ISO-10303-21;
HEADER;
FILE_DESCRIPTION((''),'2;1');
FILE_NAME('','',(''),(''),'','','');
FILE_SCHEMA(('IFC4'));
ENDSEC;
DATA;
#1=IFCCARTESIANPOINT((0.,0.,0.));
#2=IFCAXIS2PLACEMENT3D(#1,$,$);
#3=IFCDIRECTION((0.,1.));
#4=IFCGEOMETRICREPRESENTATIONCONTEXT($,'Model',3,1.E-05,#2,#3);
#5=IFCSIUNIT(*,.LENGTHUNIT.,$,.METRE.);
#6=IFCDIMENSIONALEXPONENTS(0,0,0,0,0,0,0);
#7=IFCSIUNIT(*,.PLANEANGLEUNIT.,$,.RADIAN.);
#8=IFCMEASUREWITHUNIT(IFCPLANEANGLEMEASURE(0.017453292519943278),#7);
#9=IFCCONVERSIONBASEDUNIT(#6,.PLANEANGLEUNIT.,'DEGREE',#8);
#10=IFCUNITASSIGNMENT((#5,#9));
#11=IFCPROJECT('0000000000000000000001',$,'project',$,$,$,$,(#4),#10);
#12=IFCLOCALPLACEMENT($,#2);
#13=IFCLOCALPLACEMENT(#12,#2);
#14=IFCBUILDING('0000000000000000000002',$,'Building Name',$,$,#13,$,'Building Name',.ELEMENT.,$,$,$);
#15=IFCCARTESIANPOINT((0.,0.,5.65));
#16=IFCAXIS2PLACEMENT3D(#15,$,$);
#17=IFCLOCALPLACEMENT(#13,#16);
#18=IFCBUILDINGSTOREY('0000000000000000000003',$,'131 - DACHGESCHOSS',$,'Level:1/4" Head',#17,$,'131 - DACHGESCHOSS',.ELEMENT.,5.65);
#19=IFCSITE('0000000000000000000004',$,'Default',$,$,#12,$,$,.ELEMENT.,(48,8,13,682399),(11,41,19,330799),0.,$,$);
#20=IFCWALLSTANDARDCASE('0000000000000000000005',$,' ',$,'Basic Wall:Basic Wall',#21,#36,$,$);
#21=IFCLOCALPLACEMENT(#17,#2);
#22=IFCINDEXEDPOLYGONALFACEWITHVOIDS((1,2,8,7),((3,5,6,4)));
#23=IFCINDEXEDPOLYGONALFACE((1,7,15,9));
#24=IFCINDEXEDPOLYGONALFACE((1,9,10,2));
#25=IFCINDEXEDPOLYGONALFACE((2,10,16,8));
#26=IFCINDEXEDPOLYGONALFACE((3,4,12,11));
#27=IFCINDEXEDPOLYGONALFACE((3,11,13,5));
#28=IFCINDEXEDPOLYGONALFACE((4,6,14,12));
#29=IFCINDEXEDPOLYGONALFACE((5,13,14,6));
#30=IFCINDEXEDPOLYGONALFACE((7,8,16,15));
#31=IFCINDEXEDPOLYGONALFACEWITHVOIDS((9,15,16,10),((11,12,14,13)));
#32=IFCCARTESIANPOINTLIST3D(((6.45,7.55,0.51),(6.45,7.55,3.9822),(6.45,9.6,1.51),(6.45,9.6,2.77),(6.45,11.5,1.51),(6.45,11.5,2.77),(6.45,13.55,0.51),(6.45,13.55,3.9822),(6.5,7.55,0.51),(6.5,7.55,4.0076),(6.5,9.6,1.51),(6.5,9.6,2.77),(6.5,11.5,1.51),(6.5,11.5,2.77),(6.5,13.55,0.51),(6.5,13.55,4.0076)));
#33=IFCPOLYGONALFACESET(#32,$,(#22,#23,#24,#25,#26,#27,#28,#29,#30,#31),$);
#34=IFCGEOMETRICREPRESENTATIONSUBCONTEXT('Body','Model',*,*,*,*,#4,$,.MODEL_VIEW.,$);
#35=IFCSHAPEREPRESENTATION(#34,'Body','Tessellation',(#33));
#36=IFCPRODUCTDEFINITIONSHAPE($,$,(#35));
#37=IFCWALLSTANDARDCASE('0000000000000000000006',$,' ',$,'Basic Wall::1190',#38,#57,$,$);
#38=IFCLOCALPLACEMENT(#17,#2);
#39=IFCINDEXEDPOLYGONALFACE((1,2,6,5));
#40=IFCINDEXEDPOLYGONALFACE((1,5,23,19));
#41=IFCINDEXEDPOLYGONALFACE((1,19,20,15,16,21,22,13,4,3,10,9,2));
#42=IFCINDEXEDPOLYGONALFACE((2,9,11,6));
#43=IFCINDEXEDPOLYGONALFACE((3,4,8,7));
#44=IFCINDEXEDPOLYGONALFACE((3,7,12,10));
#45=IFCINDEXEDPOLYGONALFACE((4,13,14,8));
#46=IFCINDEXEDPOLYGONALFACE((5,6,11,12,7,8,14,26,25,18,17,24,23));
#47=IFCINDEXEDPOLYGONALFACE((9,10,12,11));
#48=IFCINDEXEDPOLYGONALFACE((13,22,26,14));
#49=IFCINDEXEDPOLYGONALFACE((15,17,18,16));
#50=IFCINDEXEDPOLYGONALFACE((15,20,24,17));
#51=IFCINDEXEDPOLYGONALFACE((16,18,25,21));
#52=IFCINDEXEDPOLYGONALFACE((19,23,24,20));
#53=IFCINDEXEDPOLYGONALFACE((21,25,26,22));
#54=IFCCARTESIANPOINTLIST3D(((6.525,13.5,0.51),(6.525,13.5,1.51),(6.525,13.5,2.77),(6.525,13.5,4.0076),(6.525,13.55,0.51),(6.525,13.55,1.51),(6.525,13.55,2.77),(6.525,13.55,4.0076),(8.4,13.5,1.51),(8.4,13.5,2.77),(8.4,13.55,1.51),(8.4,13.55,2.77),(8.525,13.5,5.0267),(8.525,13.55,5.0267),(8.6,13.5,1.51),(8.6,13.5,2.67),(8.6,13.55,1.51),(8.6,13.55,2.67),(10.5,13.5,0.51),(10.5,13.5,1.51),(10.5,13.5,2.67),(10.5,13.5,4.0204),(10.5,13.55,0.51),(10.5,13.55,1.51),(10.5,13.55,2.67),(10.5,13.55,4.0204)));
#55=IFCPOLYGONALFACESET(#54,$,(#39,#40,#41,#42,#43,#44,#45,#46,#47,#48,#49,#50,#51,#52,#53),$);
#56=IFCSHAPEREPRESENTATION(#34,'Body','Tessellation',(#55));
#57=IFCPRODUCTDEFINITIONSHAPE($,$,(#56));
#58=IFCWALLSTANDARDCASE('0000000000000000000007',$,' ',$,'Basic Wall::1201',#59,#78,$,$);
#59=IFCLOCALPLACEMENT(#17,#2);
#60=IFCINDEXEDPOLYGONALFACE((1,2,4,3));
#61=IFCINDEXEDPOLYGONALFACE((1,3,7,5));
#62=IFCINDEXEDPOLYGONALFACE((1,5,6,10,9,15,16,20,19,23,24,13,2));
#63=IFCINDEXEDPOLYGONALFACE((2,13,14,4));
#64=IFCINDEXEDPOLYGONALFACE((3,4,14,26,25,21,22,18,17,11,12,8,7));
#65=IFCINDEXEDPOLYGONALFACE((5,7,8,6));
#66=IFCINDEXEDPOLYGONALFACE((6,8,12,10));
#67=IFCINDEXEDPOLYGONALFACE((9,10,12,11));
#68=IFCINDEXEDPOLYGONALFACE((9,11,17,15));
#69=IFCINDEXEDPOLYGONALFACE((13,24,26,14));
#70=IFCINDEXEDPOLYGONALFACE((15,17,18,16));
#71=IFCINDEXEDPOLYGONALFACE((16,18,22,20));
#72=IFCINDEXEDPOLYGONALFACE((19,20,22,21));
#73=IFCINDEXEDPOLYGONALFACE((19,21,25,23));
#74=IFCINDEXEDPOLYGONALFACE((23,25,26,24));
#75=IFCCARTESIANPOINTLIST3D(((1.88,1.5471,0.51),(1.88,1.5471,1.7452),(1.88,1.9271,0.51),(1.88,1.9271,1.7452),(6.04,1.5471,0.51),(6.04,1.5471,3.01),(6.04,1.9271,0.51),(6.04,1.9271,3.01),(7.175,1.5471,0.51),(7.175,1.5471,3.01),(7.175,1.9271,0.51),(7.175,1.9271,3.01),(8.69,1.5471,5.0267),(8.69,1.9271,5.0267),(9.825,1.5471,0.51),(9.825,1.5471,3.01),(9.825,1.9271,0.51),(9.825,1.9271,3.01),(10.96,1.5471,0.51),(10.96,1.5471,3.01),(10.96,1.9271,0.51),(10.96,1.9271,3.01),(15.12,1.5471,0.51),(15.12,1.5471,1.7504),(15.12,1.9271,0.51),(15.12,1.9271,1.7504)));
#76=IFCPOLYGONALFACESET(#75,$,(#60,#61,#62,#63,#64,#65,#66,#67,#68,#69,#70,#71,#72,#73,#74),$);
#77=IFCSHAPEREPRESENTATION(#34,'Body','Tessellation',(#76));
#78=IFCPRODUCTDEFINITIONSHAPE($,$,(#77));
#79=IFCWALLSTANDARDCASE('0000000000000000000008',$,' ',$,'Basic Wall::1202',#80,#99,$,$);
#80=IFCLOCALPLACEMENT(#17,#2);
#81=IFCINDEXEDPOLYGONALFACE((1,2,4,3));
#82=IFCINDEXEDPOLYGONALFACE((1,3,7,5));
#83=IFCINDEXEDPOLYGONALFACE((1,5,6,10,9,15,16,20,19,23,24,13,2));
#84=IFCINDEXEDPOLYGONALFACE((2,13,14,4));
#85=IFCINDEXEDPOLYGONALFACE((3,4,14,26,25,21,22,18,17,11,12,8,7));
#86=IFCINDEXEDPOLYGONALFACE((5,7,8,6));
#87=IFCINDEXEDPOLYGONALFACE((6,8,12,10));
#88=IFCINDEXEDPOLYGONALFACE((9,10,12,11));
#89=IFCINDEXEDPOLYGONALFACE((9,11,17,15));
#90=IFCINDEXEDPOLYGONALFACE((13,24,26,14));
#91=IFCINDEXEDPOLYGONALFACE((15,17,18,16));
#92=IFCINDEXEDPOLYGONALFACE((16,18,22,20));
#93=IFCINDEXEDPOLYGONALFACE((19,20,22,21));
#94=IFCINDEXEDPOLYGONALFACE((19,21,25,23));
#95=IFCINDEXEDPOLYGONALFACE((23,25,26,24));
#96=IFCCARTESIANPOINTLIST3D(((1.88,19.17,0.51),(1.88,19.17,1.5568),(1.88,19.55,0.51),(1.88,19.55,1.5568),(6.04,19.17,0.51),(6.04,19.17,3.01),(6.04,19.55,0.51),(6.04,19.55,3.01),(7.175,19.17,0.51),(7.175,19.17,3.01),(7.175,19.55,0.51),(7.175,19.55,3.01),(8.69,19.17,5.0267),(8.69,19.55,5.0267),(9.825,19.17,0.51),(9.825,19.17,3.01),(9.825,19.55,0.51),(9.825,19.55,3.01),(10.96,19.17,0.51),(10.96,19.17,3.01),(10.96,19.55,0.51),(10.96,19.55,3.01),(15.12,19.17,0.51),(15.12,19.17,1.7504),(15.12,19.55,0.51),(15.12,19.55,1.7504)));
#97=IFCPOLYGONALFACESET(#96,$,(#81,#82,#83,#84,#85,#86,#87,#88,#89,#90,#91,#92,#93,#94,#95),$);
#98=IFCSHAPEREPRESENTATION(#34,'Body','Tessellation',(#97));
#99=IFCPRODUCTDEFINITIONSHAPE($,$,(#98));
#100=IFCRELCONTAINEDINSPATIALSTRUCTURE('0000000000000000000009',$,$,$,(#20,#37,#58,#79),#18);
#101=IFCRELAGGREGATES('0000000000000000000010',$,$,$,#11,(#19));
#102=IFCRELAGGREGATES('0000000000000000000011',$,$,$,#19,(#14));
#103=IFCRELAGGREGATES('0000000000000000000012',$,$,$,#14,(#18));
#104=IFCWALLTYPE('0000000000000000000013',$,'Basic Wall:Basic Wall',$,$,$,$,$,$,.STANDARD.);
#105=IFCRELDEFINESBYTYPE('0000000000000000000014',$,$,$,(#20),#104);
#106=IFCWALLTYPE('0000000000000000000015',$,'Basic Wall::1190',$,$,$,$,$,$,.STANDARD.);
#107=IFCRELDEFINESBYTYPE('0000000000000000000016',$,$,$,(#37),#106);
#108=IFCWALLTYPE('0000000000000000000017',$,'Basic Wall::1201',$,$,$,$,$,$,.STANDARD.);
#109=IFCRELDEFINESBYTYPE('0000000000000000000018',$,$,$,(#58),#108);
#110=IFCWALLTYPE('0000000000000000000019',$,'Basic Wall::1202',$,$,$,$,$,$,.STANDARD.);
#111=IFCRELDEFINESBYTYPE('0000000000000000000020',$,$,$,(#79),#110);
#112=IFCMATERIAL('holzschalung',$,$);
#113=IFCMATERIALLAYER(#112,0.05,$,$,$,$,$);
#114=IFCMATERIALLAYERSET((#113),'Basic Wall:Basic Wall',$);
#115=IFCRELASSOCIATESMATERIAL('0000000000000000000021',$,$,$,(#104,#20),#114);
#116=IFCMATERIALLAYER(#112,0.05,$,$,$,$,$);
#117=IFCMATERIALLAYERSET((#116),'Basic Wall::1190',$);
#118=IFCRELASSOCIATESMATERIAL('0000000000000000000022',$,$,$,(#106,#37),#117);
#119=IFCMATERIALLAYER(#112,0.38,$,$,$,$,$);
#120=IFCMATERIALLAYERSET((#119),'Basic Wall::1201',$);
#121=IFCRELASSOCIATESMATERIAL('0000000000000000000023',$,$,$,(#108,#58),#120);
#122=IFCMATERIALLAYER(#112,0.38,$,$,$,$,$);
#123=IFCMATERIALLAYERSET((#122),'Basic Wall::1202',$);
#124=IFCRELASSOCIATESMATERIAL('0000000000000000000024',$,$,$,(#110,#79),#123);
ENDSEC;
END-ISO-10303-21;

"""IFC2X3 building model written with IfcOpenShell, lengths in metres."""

from ifc_helpers import new_model, entity, si_unit, converted_unit, direction, frame, frame_2d, origin, place, context, subcontext, project, spatial, rectangle, extrude, clip, halfspace, material, layer, layer_set, layer_usage, type_object, element, save


model = new_model("IFC2X3")

# Units and contexts
model_context = context("Model", 3, precision=1e-05, world=origin(), true_north=direction((0.0, 1.0)))
body_context = subcontext(model_context, "Body", "Model", "MODEL_VIEW")
ifc_project = project(units=[si_unit("LENGTHUNIT", "METRE"), converted_unit("PLANEANGLEUNIT", "DEGREE", entity("IfcPlaneAngleMeasure", 0.017453292519943278), si_unit("PLANEANGLEUNIT", "RADIAN"), dimensions=[0, 0, 0, 0, 0, 0, 0])], contexts=[model_context])

# Site, building, storey
site_placement = place(None, origin())
site = spatial("IfcSite", under=ifc_project, at=site_placement, Name="Default", CompositionType="ELEMENT", RefLatitude=(48, 8, 13, 682399), RefLongitude=(11, 41, 19, 330799), RefElevation=0.0)
building_placement = place(site_placement, origin())
building = spatial("IfcBuilding", under=site, at=building_placement, Name="Building Name", LongName="Building Name", CompositionType="ELEMENT")
storey_placement = place(building_placement, frame((0.0, 0.0, 5.65)))
storey = spatial("IfcBuildingStorey", under=building, at=storey_placement, Name="131 - DACHGESCHOSS", ObjectType="Level:1/4\" Head", LongName="131 - DACHGESCHOSS", CompositionType="ELEMENT", Elevation=5.65)

# Shared definitions
ifc_material = material(Name="holzschalung")

# Wall, openings
ifc_layer_1 = layer(ifc_material, 0.05)
ifc_layer_set_1 = layer_set([ifc_layer_1], Name="Basic Wall:Basic Wall")
ifc_layer_usage_1 = layer_usage(ifc_layer_set_1, "AXIS2", "NEGATIVE", 0.025)
wall_type_1 = type_object("IfcWallType", Name="Basic Wall:Basic Wall", PredefinedType="STANDARD", material=ifc_layer_set_1)
wall_1_placement = place(storey_placement, frame((6.475, 7.55, 0.51), z_axis=(0.0, 0.0, 1.0), x_axis=(0.0, 1.0, 0.0)))
wall_1 = element("IfcWallStandardCase", 1, at=wall_1_placement, inside=storey, type_object=wall_type_1, material=ifc_layer_usage_1, Name=" ", ObjectType="Basic Wall:Basic Wall", context=body_context, shape_type="SweptSolid", body=[
    extrude(rectangle(XDim=6.0, YDim=0.05, at=frame_2d((3.0, 0.0), x_axis=(-1.0, 0.0))), origin(), (0.0, 0.0, 1.0), 3.4976),
])
opening_1_placement = place(wall_1_placement, origin())
element("IfcOpeningElement", 2, at=opening_1_placement, cuts=wall_1, ObjectType="Opening", context=body_context, shape_type="SweptSolid", body=[
    extrude(rectangle(XDim=6.9075, YDim=13.815, at=frame_2d((0.0, 0.0), x_axis=(1.0, 0.0))), frame((3.0, -3.177, 8.9799), z_axis=(0.0, 0.891007, -0.45399), x_axis=(0.0, -0.45399, -0.891007)), (0.0, 0.0, 1.0), 13.815),
])
opening_2_placement = place(wall_1_placement, origin())
element("IfcOpeningElement", 3, at=opening_2_placement, cuts=wall_1, ObjectType="Opening", context=body_context, shape_type="SweptSolid", body=[
    extrude(rectangle(XDim=1.26, YDim=1.9, at=frame_2d((0.0, 0.0), x_axis=(0.0, 1.0))), frame((3.0, -0.025, 1.63), z_axis=(0.0, 1.0, 0.0), x_axis=(-1.0, 0.0, 0.0)), (0.0, 0.0, 1.0), 0.05),
])

# Walls, openings
ifc_layer_2 = layer(ifc_material, 0.05)
ifc_layer_set_2 = layer_set([ifc_layer_2], Name="Basic Wall::1190")
ifc_layer_usage_2 = layer_usage(ifc_layer_set_2, "AXIS2", "NEGATIVE", 0.025)
wall_type_2 = type_object("IfcWallType", Name="Basic Wall::1190", PredefinedType="STANDARD", material=ifc_layer_set_2)
wall_2_placement = place(storey_placement, frame((6.525, 13.525, 0.51)))
wall_2 = element("IfcWallStandardCase", 4, at=wall_2_placement, inside=storey, type_object=wall_type_2, material=ifc_layer_usage_2, Name=" ", ObjectType="Basic Wall::1190", context=body_context, shape_type="Clipping", body=[
    clip(clip(extrude(rectangle(XDim=3.975, YDim=0.05, at=frame_2d((1.9875, 0.0), x_axis=(-1.0, 0.0))), origin(), (0.0, 0.0, 1.0), 4.5167), halfspace(frame((0.0, -0.025, 3.4976), z_axis=(-0.45399, 0.0, 0.891007), x_axis=(0.0, 1.0, 0.0)), False)), halfspace(frame((2.0, -0.025, 4.5167), z_axis=(0.45399, 0.0, 0.891007), x_axis=(0.0, 1.0, 0.0)), False)),
])
opening_3_placement = place(wall_2_placement, origin())
element("IfcOpeningElement", 5, at=opening_3_placement, cuts=wall_2, ObjectType="Opening", context=body_context, shape_type="SweptSolid", body=[
    extrude(rectangle(XDim=1.26, YDim=1.9, at=frame_2d((0.0, 0.0), x_axis=(0.0, 1.0))), frame((0.925, -0.025, 1.63), z_axis=(0.0, 1.0, 0.0), x_axis=(-1.0, 0.0, 0.0)), (0.0, 0.0, 1.0), 0.05),
])
opening_4_placement = place(wall_2_placement, origin())
element("IfcOpeningElement", 6, at=opening_4_placement, cuts=wall_2, ObjectType="Opening", context=body_context, shape_type="SweptSolid", body=[
    extrude(rectangle(XDim=1.16, YDim=1.9, at=frame_2d((0.0, 0.0), x_axis=(0.0, 1.0))), frame((3.025, -0.025, 1.58), z_axis=(0.0, 1.0, 0.0), x_axis=(-1.0, 0.0, 0.0)), (0.0, 0.0, 1.0), 0.05),
])
ifc_layer_3 = layer(ifc_material, 0.38)
ifc_layer_set_3 = layer_set([ifc_layer_3], Name="Basic Wall::1201")
ifc_layer_usage_3 = layer_usage(ifc_layer_set_3, "AXIS2", "NEGATIVE", 0.19)
wall_type_3 = type_object("IfcWallType", Name="Basic Wall::1201", PredefinedType="STANDARD", material=ifc_layer_set_3)
wall_3_placement = place(storey_placement, frame((15.12, 1.7371, 0.51), z_axis=(0.0, 0.0, 1.0), x_axis=(-1.0, 0.0, 0.0)))
wall_3 = element("IfcWallStandardCase", 7, at=wall_3_placement, inside=storey, type_object=wall_type_3, material=ifc_layer_usage_3, Name=" ", ObjectType="Basic Wall::1201", context=body_context, shape_type="Clipping", body=[
    clip(clip(extrude(rectangle(XDim=13.24, YDim=0.38, at=frame_2d((6.62, 0.0), x_axis=(-1.0, 0.0))), origin(), (0.0, 0.0, 1.0), 4.5167), halfspace(frame((0.0, -0.19, 1.2404), z_axis=(-0.45399, 0.0, 0.891007), x_axis=(0.0, 1.0, 0.0)), False)), halfspace(frame((6.43, -0.19, 4.5167), z_axis=(0.434096, 0.0, 0.900866), x_axis=(0.0, 1.0, 0.0)), False)),
])
opening_5_placement = place(wall_3_placement, origin())
element("IfcOpeningElement", 8, at=opening_5_placement, cuts=wall_3, ObjectType="Opening", context=body_context, shape_type="SweptSolid", body=[
    extrude(rectangle(XDim=2.5, YDim=1.135, at=frame_2d((0.0, 0.0), x_axis=(1.0, 0.0))), frame((4.7275, -0.19, 1.25), z_axis=(0.0, 1.0, 0.0), x_axis=(0.0, 0.0, 1.0)), (0.0, 0.0, 1.0), 0.38),
])
opening_6_placement = place(wall_3_placement, origin())
element("IfcOpeningElement", 9, at=opening_6_placement, cuts=wall_3, ObjectType="Opening", context=body_context, shape_type="SweptSolid", body=[
    extrude(rectangle(XDim=2.5, YDim=1.135, at=frame_2d((0.0, 0.0), x_axis=(1.0, 0.0))), frame((8.5125, -0.19, 1.25), z_axis=(0.0, 1.0, 0.0), x_axis=(0.0, 0.0, 1.0)), (0.0, 0.0, 1.0), 0.38),
])
ifc_layer_4 = layer(ifc_material, 0.38)
ifc_layer_set_4 = layer_set([ifc_layer_4], Name="Basic Wall::1202")
ifc_layer_usage_4 = layer_usage(ifc_layer_set_4, "AXIS2", "NEGATIVE", 0.19)
wall_type_4 = type_object("IfcWallType", Name="Basic Wall::1202", PredefinedType="STANDARD", material=ifc_layer_set_4)
wall_4_placement = place(storey_placement, frame((1.88, 19.36, 0.51)))
wall_4 = element("IfcWallStandardCase", 10, at=wall_4_placement, inside=storey, type_object=wall_type_4, material=ifc_layer_usage_4, Name=" ", ObjectType="Basic Wall::1202", context=body_context, shape_type="Clipping", body=[
    clip(clip(extrude(rectangle(XDim=13.24, YDim=0.38, at=frame_2d((6.62, 0.0), x_axis=(-1.0, 0.0))), origin(), (0.0, 0.0, 1.0), 4.5167), halfspace(frame((0.0, -0.19, 1.0468), z_axis=(-0.45399, 0.0, 0.891007), x_axis=(0.0, 1.0, 0.0)), False)), halfspace(frame((6.81, -0.19, 4.5167), z_axis=(0.45399, 0.0, 0.891007), x_axis=(0.0, 1.0, 0.0)), False)),
])
opening_7_placement = place(wall_4_placement, origin())
element("IfcOpeningElement", 11, at=opening_7_placement, cuts=wall_4, ObjectType="Opening", context=body_context, shape_type="SweptSolid", body=[
    extrude(rectangle(XDim=2.5, YDim=1.135, at=frame_2d((0.0, 0.0), x_axis=(1.0, 0.0))), frame((8.5125, -0.19, 1.25), z_axis=(0.0, 1.0, 0.0), x_axis=(0.0, 0.0, 1.0)), (0.0, 0.0, 1.0), 0.38),
])
opening_8_placement = place(wall_4_placement, origin())
element("IfcOpeningElement", 12, at=opening_8_placement, cuts=wall_4, ObjectType="Opening", context=body_context, shape_type="SweptSolid", body=[
    extrude(rectangle(XDim=2.5, YDim=1.135, at=frame_2d((0.0, 0.0), x_axis=(1.0, 0.0))), frame((4.7275, -0.19, 1.25), z_axis=(0.0, 1.0, 0.0), x_axis=(0.0, 0.0, 1.0)), (0.0, 0.0, 1.0), 0.38),
])

save(model, "model.ifc")
